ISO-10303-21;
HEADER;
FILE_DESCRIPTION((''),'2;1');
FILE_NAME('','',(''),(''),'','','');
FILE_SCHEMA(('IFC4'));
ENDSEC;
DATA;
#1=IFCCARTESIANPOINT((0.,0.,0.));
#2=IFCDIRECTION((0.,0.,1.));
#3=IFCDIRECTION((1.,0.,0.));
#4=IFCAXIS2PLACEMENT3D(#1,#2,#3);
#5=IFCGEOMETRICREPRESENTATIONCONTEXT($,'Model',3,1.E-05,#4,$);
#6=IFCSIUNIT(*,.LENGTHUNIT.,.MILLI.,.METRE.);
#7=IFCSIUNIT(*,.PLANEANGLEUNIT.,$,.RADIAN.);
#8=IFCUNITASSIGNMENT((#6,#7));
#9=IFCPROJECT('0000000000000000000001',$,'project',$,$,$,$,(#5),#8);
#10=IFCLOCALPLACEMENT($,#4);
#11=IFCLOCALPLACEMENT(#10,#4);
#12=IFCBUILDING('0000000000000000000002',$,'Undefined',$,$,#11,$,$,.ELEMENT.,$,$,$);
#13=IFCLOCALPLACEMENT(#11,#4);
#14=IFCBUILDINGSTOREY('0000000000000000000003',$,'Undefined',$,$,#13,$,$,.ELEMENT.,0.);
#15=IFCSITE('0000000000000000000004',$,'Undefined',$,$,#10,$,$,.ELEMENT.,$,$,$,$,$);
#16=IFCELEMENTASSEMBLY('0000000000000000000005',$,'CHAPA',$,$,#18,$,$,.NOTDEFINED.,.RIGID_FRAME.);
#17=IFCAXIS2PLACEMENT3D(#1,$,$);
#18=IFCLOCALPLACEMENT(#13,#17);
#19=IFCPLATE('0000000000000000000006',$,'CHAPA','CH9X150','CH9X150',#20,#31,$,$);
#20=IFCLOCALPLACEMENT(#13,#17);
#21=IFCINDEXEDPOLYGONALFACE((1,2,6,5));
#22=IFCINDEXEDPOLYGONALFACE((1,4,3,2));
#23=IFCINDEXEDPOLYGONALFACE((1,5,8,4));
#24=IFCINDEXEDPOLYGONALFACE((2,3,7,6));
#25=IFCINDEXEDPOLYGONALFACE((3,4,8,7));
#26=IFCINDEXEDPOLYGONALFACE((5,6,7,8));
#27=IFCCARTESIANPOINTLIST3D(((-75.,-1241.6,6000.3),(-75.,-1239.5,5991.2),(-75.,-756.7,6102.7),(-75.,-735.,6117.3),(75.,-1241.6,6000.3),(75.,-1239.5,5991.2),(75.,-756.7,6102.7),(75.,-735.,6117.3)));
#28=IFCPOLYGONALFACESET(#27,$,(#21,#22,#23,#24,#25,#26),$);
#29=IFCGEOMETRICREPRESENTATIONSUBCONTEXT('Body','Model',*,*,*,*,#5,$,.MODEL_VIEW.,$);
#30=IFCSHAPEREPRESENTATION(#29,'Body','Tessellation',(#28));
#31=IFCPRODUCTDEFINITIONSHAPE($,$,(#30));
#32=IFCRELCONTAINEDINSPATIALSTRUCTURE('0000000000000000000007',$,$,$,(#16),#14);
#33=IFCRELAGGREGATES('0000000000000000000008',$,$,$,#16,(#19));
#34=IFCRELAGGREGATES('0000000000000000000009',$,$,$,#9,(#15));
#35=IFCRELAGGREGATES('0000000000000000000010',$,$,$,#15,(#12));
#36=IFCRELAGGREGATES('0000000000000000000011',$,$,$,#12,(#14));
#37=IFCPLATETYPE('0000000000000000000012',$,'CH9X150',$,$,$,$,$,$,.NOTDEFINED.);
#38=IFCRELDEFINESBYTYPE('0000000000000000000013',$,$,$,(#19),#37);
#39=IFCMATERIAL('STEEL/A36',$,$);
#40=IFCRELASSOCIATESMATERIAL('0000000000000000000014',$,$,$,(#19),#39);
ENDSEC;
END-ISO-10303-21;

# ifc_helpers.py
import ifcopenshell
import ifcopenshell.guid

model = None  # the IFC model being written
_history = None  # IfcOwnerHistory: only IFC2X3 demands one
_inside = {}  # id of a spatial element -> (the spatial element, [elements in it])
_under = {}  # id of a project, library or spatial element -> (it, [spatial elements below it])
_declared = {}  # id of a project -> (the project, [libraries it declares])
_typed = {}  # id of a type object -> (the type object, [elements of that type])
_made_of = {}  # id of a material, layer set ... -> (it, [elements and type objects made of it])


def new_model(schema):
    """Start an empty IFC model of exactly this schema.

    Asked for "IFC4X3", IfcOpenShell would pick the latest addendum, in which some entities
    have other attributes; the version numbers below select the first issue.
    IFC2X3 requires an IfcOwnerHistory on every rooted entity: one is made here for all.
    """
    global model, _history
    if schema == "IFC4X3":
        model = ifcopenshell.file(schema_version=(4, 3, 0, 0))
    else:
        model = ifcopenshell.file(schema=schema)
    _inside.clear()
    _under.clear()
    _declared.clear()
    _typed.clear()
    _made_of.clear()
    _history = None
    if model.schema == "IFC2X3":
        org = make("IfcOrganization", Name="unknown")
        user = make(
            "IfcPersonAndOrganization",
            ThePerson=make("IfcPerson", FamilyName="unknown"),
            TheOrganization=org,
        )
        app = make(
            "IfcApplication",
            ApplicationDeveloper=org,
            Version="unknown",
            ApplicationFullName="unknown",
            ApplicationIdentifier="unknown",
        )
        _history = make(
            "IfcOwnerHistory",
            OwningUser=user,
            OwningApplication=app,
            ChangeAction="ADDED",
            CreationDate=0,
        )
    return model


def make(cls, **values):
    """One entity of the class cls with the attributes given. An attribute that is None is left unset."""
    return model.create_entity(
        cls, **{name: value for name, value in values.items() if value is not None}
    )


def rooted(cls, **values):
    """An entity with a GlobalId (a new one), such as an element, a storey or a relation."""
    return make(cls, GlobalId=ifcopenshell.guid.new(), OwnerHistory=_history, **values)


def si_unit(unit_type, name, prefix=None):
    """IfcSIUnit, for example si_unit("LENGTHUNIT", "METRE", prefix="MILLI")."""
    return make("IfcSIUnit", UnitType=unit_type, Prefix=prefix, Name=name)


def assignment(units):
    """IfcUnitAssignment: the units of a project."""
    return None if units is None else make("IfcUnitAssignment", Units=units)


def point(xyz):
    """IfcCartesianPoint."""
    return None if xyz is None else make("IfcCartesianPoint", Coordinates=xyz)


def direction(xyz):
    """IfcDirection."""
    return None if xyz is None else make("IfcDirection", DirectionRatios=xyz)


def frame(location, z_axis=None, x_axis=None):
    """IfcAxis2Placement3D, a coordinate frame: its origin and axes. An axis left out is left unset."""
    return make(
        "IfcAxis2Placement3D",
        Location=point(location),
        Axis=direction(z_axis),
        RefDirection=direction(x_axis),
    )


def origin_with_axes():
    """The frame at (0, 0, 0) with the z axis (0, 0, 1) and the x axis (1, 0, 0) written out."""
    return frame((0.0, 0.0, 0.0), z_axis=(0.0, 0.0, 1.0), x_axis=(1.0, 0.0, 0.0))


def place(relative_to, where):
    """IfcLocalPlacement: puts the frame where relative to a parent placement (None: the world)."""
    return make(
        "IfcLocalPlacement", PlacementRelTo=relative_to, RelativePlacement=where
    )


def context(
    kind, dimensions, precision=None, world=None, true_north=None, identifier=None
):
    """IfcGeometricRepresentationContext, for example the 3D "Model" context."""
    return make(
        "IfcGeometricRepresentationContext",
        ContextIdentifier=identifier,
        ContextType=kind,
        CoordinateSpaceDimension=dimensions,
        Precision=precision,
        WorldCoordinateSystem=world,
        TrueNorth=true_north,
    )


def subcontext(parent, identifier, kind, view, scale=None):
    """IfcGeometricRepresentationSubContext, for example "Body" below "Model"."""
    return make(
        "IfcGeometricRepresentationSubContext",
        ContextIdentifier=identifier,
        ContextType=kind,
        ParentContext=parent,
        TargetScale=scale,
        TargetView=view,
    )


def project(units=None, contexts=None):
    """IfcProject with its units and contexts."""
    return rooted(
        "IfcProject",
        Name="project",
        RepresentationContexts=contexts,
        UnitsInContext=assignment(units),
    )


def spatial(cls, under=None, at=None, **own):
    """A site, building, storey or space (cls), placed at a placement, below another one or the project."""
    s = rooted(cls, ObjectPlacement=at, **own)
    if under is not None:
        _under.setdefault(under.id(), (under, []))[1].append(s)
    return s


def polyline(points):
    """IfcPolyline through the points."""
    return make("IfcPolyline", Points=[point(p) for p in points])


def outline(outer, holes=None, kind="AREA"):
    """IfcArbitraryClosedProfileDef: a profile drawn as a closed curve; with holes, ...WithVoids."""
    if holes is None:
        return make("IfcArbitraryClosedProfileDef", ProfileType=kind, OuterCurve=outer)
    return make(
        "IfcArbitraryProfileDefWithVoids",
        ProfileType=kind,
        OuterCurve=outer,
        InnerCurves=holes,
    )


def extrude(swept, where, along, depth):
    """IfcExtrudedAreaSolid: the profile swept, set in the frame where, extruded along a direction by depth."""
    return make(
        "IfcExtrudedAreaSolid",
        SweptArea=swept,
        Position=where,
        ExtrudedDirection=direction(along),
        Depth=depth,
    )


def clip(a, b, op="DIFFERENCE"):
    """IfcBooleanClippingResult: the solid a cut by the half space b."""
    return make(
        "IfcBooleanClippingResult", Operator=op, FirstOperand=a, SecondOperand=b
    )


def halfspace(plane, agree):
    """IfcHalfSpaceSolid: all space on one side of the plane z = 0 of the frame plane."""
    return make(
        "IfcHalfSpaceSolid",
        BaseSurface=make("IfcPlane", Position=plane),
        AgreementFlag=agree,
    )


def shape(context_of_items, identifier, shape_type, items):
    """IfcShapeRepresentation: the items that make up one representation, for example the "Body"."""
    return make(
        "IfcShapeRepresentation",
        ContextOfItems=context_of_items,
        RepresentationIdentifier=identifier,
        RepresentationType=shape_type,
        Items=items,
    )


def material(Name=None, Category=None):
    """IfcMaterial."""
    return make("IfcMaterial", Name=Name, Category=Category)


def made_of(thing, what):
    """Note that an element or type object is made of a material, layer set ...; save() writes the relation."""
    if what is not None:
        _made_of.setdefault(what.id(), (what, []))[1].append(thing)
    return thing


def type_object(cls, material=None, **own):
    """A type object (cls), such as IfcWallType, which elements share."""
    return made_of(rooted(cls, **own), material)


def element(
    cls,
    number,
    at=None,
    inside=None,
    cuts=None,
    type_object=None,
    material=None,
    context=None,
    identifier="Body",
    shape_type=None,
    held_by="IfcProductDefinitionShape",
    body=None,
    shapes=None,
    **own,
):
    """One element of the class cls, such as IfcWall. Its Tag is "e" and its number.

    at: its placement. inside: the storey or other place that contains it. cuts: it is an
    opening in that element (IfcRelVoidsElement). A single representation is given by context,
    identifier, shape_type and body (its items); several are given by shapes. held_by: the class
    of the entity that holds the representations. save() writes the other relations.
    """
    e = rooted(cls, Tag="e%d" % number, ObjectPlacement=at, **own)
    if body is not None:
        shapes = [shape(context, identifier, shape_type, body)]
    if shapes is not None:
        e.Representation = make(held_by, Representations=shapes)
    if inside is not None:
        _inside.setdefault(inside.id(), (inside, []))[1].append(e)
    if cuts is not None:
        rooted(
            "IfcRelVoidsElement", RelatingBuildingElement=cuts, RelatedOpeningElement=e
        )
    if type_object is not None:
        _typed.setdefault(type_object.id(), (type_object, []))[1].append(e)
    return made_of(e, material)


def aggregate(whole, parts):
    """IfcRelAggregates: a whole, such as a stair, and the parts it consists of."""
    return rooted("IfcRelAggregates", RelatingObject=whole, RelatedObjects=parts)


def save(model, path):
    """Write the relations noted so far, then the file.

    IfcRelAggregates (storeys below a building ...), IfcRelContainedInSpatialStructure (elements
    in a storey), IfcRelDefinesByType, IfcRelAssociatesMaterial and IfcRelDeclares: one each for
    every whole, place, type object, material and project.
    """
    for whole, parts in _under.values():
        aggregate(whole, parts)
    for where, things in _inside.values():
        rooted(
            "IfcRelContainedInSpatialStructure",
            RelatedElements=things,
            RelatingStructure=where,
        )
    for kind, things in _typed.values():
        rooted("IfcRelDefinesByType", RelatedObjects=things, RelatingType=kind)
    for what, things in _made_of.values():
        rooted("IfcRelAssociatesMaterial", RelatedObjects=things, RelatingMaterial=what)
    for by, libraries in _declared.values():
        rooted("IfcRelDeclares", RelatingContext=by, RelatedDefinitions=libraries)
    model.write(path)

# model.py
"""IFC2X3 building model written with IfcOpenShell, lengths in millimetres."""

from ifc_helpers import new_model, si_unit, frame, origin_with_axes, place, context, subcontext, project, spatial, polyline, outline, extrude, clip, halfspace, material, type_object, element, aggregate, save


model = new_model("IFC2X3")

# Units and contexts
model_context = context("Model", 3, precision=1e-05, world=origin_with_axes())
body_context = subcontext(model_context, "Body", "Model", "MODEL_VIEW")
ifc_project = project(units=[si_unit("LENGTHUNIT", "METRE", prefix="MILLI"), si_unit("PLANEANGLEUNIT", "RADIAN")], contexts=[model_context])

# Site, building, storey
site_placement = place(None, origin_with_axes())
site = spatial("IfcSite", under=ifc_project, at=site_placement, Name="Undefined", CompositionType="ELEMENT")
building_placement = place(site_placement, origin_with_axes())
building = spatial("IfcBuilding", under=site, at=building_placement, Name="Undefined", CompositionType="ELEMENT")
storey_placement = place(building_placement, origin_with_axes())
storey = spatial("IfcBuildingStorey", under=building, at=storey_placement, Name="Undefined", CompositionType="ELEMENT", Elevation=0.0)

# Shared definitions
ifc_material_1 = material(Name="STEEL/A36")

# Element assembly, plate
plate_type_1 = type_object("IfcPlateType", Name="CH9X150", PredefinedType="NOTDEFINED")
assembly_1_placement = place(storey_placement, origin_with_axes())
assembly_1 = element("IfcElementAssembly", 1, at=assembly_1_placement, inside=storey, Name="CHAPA", AssemblyPlace="NOTDEFINED", PredefinedType="RIGID_FRAME")
plate_1_placement = place(assembly_1_placement, frame((75.0, -1240.6, 5995.7), z_axis=(0.0, -0.225124, 0.97433), x_axis=(0.0, 0.97433, 0.225124)))
plate_1 = element("IfcPlate", 2, at=plate_1_placement, type_object=plate_type_1, material=ifc_material_1, Name="CHAPA", Description="CH9X150", ObjectType="CH9X150", context=body_context, shape_type="Clipping", body=[
    clip(extrude(outline(polyline([(0.0, 0.0), (520.0, 0.0), (520.0, 150.0), (0.0, 150.0), (0.0, 0.0)])), frame((0.0, 0.0, -4.7), z_axis=(0.0, 0.0, 1.0), x_axis=(1.0, 0.0, 0.0)), (0.0, 0.0, 1.0), 9.3), halfspace(frame((520.0, -500.0, 4.7), z_axis=(0.354778, 0.0, -0.934951), x_axis=(0.0, 1.0, 0.0)), False)),
])
aggregate(assembly_1, [plate_1])

save(model, "model.ifc")
